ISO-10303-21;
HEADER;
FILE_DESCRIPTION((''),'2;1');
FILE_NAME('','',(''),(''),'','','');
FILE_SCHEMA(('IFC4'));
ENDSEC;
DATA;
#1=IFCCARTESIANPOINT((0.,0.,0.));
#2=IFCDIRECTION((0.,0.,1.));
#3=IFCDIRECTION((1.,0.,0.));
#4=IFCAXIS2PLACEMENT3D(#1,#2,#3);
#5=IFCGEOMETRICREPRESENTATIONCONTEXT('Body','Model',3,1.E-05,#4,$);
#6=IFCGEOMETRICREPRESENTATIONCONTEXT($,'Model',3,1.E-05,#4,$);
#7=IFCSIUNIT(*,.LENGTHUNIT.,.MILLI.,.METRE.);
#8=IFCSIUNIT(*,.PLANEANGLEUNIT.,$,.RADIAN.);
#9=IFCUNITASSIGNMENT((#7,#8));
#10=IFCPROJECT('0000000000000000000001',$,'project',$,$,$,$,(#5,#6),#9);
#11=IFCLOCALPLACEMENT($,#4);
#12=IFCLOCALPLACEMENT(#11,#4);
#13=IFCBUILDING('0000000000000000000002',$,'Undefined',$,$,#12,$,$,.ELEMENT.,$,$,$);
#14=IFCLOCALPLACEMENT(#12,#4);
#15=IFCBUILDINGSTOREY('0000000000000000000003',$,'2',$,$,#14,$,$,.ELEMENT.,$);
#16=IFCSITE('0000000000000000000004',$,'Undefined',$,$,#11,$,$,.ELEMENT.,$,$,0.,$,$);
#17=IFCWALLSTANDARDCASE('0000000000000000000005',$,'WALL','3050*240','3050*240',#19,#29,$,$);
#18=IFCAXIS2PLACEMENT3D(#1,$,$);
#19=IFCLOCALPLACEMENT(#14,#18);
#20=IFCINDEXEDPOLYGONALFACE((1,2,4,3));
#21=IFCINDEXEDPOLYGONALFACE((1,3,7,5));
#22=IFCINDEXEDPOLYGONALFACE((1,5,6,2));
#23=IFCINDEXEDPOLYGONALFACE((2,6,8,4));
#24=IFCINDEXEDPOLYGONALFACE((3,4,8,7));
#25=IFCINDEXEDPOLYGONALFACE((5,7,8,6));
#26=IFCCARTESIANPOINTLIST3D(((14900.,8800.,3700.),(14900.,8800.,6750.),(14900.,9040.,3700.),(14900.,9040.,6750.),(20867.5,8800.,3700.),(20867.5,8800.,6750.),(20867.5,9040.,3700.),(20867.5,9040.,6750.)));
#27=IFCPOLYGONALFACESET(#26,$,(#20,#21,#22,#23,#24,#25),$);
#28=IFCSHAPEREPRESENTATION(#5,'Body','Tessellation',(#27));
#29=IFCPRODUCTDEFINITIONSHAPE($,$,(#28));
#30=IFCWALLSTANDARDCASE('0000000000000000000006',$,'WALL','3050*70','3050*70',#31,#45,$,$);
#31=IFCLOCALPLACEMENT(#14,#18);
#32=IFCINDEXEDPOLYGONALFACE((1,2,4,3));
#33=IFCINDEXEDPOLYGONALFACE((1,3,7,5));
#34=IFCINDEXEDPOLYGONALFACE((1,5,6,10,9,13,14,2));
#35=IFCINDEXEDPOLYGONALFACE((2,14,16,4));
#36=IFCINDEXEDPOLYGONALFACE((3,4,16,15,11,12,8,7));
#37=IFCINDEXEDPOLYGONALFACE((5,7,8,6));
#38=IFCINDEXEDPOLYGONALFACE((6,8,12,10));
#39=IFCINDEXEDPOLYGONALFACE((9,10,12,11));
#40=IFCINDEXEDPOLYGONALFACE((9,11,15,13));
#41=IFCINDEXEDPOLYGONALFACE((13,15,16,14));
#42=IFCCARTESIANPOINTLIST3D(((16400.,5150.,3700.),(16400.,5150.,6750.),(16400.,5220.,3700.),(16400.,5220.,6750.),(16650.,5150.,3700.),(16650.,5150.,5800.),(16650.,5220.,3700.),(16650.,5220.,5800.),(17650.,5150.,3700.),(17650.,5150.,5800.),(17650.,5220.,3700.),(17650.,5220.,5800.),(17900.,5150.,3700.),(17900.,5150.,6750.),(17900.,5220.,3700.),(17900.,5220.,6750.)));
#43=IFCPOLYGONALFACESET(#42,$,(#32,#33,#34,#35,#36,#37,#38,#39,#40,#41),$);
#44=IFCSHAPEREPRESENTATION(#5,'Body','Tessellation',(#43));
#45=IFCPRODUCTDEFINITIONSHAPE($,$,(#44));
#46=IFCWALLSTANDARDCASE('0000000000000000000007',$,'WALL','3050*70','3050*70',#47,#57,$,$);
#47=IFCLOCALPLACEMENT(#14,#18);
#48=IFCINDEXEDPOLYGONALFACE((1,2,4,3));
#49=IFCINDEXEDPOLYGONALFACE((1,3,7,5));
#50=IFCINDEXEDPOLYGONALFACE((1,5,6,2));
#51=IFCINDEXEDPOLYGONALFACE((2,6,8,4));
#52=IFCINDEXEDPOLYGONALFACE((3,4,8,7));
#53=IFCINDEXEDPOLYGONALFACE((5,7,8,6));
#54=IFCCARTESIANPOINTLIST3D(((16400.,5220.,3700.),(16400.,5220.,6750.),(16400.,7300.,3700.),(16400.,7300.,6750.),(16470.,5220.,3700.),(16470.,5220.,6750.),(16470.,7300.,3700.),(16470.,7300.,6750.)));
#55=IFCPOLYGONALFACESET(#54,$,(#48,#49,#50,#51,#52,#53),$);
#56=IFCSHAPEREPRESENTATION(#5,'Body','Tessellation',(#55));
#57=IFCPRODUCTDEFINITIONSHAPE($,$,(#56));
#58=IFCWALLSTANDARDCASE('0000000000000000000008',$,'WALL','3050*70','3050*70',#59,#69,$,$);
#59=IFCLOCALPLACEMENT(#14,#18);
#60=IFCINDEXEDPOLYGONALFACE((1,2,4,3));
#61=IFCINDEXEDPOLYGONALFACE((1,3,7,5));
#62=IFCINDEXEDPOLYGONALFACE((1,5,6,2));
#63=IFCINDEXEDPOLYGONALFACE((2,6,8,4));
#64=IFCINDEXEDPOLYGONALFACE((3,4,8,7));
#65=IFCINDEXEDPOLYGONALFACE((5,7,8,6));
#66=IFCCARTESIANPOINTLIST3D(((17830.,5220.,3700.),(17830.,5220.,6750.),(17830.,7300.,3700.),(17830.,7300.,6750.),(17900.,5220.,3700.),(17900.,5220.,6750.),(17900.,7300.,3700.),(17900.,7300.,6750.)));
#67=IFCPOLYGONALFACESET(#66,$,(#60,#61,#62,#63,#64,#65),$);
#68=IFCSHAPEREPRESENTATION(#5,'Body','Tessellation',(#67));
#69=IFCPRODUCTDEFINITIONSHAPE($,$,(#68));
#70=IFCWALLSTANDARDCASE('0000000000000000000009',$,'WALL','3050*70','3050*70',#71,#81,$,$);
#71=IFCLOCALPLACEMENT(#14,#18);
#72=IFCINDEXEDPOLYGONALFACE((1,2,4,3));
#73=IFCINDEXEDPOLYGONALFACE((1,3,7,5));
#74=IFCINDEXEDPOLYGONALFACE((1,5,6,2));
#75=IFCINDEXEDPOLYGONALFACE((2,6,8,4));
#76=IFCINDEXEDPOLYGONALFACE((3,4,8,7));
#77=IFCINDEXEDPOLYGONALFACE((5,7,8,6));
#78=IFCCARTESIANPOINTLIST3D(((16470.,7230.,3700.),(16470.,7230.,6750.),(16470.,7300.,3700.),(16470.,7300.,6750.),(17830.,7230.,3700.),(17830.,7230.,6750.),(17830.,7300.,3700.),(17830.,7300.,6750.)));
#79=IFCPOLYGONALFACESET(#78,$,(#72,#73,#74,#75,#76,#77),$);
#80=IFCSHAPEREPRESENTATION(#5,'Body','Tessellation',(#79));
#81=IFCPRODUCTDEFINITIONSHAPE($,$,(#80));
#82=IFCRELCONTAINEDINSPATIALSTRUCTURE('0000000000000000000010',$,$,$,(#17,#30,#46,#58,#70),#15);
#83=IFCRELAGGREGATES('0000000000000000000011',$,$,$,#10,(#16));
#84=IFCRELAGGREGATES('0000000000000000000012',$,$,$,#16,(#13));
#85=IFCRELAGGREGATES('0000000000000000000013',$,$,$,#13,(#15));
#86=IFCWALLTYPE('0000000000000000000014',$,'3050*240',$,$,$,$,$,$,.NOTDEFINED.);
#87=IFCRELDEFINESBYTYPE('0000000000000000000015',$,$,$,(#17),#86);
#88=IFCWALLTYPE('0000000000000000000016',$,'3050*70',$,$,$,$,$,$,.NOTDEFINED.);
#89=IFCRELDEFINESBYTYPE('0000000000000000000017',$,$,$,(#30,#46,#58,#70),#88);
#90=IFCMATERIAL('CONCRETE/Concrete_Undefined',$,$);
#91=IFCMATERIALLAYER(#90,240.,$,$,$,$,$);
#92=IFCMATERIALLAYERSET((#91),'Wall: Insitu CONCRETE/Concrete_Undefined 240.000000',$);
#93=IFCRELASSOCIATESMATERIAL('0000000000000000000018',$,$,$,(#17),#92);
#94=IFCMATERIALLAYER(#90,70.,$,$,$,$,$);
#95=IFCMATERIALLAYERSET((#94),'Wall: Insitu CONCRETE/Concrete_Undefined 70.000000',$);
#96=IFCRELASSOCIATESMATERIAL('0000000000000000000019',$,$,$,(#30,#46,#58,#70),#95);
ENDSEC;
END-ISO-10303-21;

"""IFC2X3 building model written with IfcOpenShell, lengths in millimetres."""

from ifc_helpers import new_model, si_unit, frame, frame_2d, origin_with_axes, place, context, project, spatial, polyline, rectangle, outline, extrude, material, layer, layer_set, layer_usage, type_object, element, save


model = new_model("IFC2X3")

# Units and contexts
model_context_1 = context("Model", 3, precision=1e-05, world=origin_with_axes(), identifier="Body")
model_context_2 = context("Model", 3, precision=1e-05, world=origin_with_axes())
ifc_project = project(units=[si_unit("LENGTHUNIT", "METRE", prefix="MILLI"), si_unit("PLANEANGLEUNIT", "RADIAN")], contexts=[model_context_1, model_context_2])

# Site, building, storey
site_placement = place(None, origin_with_axes())
site = spatial("IfcSite", under=ifc_project, at=site_placement, Name="Undefined", CompositionType="ELEMENT", RefElevation=0.0)
building_placement = place(site_placement, origin_with_axes())
building = spatial("IfcBuilding", under=site, at=building_placement, Name="Undefined", CompositionType="ELEMENT")
storey_placement = place(building_placement, origin_with_axes())
storey = spatial("IfcBuildingStorey", under=building, at=storey_placement, Name="2", CompositionType="ELEMENT")

# Shared definitions
ifc_material = material(Name="CONCRETE/Concrete_Undefined")

# Shared definitions
ifc_layer_1 = layer(ifc_material, 240.0)
ifc_layer_set_1 = layer_set([ifc_layer_1], Name="Wall: Insitu CONCRETE/Concrete_Undefined 240.000000")

# Wall
ifc_layer_usage_1 = layer_usage(ifc_layer_set_1, "AXIS2", "POSITIVE", -120.0)
wall_type_1 = type_object("IfcWallType", Name="3050*240", PredefinedType="NOTDEFINED")
wall_1_placement = place(storey_placement, frame((20867.5, 8920.0, 3700.0), z_axis=(0.0, 0.0, 1.0), x_axis=(-1.0, 0.0, 0.0)))
element("IfcWallStandardCase", 1, at=wall_1_placement, inside=storey, type_object=wall_type_1, material=ifc_layer_usage_1, Name="WALL", Description="3050*240", ObjectType="3050*240", context=model_context_1, shape_type="SweptSolid", body=[
    extrude(rectangle(XDim=5967.5, YDim=240.0, at=frame_2d((0.0, 2983.8), x_axis=(0.0, -1.0))), frame((0.0, 0.0, 0.0), z_axis=(0.0, 0.0, 1.0), x_axis=(0.0, -1.0, 0.0)), (0.0, 0.0, 1.0), 3050.0),
])

# Wall, opening
ifc_layer_2 = layer(ifc_material, 70.0)
ifc_layer_set_2 = layer_set([ifc_layer_2], Name="Wall: Insitu CONCRETE/Concrete_Undefined 70.000000")
ifc_layer_usage_2 = layer_usage(ifc_layer_set_2, "AXIS2", "POSITIVE", -35.0)
wall_type_2 = type_object("IfcWallType", Name="3050*70", PredefinedType="NOTDEFINED")
wall_2_placement = place(storey_placement, frame((16400.0, 5185.0, 3700.0), z_axis=(0.0, 0.0, 1.0), x_axis=(1.0, 0.0, 0.0)))
wall_2 = element("IfcWallStandardCase", 2, at=wall_2_placement, inside=storey, type_object=wall_type_2, material=ifc_layer_usage_2, Name="WALL", Description="3050*70", ObjectType="3050*70", context=model_context_1, shape_type="SweptSolid", body=[
    extrude(rectangle(XDim=1500.0, YDim=70.0, at=frame_2d((0.0, 750.0), x_axis=(0.0, -1.0))), frame((0.0, 0.0, 0.0), z_axis=(0.0, 0.0, 1.0), x_axis=(0.0, -1.0, 0.0)), (0.0, 0.0, 1.0), 3050.0),
])
opening_1_placement = place(storey_placement, frame((16400.0, 5185.0, 3700.0), z_axis=(0.0, 0.0, 1.0), x_axis=(1.0, 0.0, 0.0)))
element("IfcOpeningElement", 3, at=opening_1_placement, cuts=wall_2, ObjectType="Recess", context=model_context_1, shape_type="SweptSolid", body=[
    extrude(outline(polyline([(0.0, 0.0), (1000.0, 0.0), (1000.0, 2100.0), (0.0, 2100.0), (0.0, 0.0)])), frame((250.0, -38.0, 2100.0), z_axis=(0.0, 1.0, 0.0), x_axis=(1.0, 0.0, 0.0)), (0.0, 0.0, 1.0), 76.0),
])

# Walls
ifc_layer_usage_3 = layer_usage(ifc_layer_set_2, "AXIS2", "POSITIVE", -35.0)
wall_3_placement = place(storey_placement, frame((16435.0, 7300.0, 3700.0), z_axis=(0.0, 0.0, 1.0), x_axis=(0.0, -1.0, 0.0)))
element("IfcWallStandardCase", 4, at=wall_3_placement, inside=storey, type_object=wall_type_2, material=ifc_layer_usage_3, Name="WALL", Description="3050*70", ObjectType="3050*70", context=model_context_1, shape_type="SweptSolid", body=[
    extrude(rectangle(XDim=2080.0, YDim=70.0, at=frame_2d((0.0, 1040.0), x_axis=(0.0, -1.0))), frame((0.0, 0.0, 0.0), z_axis=(0.0, 0.0, 1.0), x_axis=(0.0, -1.0, 0.0)), (0.0, 0.0, 1.0), 3050.0),
])
ifc_layer_usage_4 = layer_usage(ifc_layer_set_2, "AXIS2", "POSITIVE", -35.0)
wall_4_placement = place(storey_placement, frame((17865.0, 5220.0, 3700.0), z_axis=(0.0, 0.0, 1.0), x_axis=(0.0, 1.0, 0.0)))
element("IfcWallStandardCase", 5, at=wall_4_placement, inside=storey, type_object=wall_type_2, material=ifc_layer_usage_4, Name="WALL", Description="3050*70", ObjectType="3050*70", context=model_context_1, shape_type="SweptSolid", body=[
    extrude(rectangle(XDim=2080.0, YDim=70.0, at=frame_2d((0.0, 1040.0), x_axis=(0.0, -1.0))), frame((0.0, 0.0, 0.0), z_axis=(0.0, 0.0, 1.0), x_axis=(0.0, -1.0, 0.0)), (0.0, 0.0, 1.0), 3050.0),
])
ifc_layer_usage_5 = layer_usage(ifc_layer_set_2, "AXIS2", "POSITIVE", -35.0)
wall_5_placement = place(storey_placement, frame((17830.0, 7265.0, 3700.0), z_axis=(0.0, 0.0, 1.0), x_axis=(-1.0, 0.0, 0.0)))
element("IfcWallStandardCase", 6, at=wall_5_placement, inside=storey, type_object=wall_type_2, material=ifc_layer_usage_5, Name="WALL", Description="3050*70", ObjectType="3050*70", context=model_context_1, shape_type="SweptSolid", body=[
    extrude(rectangle(XDim=1360.0, YDim=70.0, at=frame_2d((0.0, 680.0), x_axis=(0.0, -1.0))), frame((0.0, 0.0, 0.0), z_axis=(0.0, 0.0, 1.0), x_axis=(0.0, -1.0, 0.0)), (0.0, 0.0, 1.0), 3050.0),
])

save(model, "model.ifc")
